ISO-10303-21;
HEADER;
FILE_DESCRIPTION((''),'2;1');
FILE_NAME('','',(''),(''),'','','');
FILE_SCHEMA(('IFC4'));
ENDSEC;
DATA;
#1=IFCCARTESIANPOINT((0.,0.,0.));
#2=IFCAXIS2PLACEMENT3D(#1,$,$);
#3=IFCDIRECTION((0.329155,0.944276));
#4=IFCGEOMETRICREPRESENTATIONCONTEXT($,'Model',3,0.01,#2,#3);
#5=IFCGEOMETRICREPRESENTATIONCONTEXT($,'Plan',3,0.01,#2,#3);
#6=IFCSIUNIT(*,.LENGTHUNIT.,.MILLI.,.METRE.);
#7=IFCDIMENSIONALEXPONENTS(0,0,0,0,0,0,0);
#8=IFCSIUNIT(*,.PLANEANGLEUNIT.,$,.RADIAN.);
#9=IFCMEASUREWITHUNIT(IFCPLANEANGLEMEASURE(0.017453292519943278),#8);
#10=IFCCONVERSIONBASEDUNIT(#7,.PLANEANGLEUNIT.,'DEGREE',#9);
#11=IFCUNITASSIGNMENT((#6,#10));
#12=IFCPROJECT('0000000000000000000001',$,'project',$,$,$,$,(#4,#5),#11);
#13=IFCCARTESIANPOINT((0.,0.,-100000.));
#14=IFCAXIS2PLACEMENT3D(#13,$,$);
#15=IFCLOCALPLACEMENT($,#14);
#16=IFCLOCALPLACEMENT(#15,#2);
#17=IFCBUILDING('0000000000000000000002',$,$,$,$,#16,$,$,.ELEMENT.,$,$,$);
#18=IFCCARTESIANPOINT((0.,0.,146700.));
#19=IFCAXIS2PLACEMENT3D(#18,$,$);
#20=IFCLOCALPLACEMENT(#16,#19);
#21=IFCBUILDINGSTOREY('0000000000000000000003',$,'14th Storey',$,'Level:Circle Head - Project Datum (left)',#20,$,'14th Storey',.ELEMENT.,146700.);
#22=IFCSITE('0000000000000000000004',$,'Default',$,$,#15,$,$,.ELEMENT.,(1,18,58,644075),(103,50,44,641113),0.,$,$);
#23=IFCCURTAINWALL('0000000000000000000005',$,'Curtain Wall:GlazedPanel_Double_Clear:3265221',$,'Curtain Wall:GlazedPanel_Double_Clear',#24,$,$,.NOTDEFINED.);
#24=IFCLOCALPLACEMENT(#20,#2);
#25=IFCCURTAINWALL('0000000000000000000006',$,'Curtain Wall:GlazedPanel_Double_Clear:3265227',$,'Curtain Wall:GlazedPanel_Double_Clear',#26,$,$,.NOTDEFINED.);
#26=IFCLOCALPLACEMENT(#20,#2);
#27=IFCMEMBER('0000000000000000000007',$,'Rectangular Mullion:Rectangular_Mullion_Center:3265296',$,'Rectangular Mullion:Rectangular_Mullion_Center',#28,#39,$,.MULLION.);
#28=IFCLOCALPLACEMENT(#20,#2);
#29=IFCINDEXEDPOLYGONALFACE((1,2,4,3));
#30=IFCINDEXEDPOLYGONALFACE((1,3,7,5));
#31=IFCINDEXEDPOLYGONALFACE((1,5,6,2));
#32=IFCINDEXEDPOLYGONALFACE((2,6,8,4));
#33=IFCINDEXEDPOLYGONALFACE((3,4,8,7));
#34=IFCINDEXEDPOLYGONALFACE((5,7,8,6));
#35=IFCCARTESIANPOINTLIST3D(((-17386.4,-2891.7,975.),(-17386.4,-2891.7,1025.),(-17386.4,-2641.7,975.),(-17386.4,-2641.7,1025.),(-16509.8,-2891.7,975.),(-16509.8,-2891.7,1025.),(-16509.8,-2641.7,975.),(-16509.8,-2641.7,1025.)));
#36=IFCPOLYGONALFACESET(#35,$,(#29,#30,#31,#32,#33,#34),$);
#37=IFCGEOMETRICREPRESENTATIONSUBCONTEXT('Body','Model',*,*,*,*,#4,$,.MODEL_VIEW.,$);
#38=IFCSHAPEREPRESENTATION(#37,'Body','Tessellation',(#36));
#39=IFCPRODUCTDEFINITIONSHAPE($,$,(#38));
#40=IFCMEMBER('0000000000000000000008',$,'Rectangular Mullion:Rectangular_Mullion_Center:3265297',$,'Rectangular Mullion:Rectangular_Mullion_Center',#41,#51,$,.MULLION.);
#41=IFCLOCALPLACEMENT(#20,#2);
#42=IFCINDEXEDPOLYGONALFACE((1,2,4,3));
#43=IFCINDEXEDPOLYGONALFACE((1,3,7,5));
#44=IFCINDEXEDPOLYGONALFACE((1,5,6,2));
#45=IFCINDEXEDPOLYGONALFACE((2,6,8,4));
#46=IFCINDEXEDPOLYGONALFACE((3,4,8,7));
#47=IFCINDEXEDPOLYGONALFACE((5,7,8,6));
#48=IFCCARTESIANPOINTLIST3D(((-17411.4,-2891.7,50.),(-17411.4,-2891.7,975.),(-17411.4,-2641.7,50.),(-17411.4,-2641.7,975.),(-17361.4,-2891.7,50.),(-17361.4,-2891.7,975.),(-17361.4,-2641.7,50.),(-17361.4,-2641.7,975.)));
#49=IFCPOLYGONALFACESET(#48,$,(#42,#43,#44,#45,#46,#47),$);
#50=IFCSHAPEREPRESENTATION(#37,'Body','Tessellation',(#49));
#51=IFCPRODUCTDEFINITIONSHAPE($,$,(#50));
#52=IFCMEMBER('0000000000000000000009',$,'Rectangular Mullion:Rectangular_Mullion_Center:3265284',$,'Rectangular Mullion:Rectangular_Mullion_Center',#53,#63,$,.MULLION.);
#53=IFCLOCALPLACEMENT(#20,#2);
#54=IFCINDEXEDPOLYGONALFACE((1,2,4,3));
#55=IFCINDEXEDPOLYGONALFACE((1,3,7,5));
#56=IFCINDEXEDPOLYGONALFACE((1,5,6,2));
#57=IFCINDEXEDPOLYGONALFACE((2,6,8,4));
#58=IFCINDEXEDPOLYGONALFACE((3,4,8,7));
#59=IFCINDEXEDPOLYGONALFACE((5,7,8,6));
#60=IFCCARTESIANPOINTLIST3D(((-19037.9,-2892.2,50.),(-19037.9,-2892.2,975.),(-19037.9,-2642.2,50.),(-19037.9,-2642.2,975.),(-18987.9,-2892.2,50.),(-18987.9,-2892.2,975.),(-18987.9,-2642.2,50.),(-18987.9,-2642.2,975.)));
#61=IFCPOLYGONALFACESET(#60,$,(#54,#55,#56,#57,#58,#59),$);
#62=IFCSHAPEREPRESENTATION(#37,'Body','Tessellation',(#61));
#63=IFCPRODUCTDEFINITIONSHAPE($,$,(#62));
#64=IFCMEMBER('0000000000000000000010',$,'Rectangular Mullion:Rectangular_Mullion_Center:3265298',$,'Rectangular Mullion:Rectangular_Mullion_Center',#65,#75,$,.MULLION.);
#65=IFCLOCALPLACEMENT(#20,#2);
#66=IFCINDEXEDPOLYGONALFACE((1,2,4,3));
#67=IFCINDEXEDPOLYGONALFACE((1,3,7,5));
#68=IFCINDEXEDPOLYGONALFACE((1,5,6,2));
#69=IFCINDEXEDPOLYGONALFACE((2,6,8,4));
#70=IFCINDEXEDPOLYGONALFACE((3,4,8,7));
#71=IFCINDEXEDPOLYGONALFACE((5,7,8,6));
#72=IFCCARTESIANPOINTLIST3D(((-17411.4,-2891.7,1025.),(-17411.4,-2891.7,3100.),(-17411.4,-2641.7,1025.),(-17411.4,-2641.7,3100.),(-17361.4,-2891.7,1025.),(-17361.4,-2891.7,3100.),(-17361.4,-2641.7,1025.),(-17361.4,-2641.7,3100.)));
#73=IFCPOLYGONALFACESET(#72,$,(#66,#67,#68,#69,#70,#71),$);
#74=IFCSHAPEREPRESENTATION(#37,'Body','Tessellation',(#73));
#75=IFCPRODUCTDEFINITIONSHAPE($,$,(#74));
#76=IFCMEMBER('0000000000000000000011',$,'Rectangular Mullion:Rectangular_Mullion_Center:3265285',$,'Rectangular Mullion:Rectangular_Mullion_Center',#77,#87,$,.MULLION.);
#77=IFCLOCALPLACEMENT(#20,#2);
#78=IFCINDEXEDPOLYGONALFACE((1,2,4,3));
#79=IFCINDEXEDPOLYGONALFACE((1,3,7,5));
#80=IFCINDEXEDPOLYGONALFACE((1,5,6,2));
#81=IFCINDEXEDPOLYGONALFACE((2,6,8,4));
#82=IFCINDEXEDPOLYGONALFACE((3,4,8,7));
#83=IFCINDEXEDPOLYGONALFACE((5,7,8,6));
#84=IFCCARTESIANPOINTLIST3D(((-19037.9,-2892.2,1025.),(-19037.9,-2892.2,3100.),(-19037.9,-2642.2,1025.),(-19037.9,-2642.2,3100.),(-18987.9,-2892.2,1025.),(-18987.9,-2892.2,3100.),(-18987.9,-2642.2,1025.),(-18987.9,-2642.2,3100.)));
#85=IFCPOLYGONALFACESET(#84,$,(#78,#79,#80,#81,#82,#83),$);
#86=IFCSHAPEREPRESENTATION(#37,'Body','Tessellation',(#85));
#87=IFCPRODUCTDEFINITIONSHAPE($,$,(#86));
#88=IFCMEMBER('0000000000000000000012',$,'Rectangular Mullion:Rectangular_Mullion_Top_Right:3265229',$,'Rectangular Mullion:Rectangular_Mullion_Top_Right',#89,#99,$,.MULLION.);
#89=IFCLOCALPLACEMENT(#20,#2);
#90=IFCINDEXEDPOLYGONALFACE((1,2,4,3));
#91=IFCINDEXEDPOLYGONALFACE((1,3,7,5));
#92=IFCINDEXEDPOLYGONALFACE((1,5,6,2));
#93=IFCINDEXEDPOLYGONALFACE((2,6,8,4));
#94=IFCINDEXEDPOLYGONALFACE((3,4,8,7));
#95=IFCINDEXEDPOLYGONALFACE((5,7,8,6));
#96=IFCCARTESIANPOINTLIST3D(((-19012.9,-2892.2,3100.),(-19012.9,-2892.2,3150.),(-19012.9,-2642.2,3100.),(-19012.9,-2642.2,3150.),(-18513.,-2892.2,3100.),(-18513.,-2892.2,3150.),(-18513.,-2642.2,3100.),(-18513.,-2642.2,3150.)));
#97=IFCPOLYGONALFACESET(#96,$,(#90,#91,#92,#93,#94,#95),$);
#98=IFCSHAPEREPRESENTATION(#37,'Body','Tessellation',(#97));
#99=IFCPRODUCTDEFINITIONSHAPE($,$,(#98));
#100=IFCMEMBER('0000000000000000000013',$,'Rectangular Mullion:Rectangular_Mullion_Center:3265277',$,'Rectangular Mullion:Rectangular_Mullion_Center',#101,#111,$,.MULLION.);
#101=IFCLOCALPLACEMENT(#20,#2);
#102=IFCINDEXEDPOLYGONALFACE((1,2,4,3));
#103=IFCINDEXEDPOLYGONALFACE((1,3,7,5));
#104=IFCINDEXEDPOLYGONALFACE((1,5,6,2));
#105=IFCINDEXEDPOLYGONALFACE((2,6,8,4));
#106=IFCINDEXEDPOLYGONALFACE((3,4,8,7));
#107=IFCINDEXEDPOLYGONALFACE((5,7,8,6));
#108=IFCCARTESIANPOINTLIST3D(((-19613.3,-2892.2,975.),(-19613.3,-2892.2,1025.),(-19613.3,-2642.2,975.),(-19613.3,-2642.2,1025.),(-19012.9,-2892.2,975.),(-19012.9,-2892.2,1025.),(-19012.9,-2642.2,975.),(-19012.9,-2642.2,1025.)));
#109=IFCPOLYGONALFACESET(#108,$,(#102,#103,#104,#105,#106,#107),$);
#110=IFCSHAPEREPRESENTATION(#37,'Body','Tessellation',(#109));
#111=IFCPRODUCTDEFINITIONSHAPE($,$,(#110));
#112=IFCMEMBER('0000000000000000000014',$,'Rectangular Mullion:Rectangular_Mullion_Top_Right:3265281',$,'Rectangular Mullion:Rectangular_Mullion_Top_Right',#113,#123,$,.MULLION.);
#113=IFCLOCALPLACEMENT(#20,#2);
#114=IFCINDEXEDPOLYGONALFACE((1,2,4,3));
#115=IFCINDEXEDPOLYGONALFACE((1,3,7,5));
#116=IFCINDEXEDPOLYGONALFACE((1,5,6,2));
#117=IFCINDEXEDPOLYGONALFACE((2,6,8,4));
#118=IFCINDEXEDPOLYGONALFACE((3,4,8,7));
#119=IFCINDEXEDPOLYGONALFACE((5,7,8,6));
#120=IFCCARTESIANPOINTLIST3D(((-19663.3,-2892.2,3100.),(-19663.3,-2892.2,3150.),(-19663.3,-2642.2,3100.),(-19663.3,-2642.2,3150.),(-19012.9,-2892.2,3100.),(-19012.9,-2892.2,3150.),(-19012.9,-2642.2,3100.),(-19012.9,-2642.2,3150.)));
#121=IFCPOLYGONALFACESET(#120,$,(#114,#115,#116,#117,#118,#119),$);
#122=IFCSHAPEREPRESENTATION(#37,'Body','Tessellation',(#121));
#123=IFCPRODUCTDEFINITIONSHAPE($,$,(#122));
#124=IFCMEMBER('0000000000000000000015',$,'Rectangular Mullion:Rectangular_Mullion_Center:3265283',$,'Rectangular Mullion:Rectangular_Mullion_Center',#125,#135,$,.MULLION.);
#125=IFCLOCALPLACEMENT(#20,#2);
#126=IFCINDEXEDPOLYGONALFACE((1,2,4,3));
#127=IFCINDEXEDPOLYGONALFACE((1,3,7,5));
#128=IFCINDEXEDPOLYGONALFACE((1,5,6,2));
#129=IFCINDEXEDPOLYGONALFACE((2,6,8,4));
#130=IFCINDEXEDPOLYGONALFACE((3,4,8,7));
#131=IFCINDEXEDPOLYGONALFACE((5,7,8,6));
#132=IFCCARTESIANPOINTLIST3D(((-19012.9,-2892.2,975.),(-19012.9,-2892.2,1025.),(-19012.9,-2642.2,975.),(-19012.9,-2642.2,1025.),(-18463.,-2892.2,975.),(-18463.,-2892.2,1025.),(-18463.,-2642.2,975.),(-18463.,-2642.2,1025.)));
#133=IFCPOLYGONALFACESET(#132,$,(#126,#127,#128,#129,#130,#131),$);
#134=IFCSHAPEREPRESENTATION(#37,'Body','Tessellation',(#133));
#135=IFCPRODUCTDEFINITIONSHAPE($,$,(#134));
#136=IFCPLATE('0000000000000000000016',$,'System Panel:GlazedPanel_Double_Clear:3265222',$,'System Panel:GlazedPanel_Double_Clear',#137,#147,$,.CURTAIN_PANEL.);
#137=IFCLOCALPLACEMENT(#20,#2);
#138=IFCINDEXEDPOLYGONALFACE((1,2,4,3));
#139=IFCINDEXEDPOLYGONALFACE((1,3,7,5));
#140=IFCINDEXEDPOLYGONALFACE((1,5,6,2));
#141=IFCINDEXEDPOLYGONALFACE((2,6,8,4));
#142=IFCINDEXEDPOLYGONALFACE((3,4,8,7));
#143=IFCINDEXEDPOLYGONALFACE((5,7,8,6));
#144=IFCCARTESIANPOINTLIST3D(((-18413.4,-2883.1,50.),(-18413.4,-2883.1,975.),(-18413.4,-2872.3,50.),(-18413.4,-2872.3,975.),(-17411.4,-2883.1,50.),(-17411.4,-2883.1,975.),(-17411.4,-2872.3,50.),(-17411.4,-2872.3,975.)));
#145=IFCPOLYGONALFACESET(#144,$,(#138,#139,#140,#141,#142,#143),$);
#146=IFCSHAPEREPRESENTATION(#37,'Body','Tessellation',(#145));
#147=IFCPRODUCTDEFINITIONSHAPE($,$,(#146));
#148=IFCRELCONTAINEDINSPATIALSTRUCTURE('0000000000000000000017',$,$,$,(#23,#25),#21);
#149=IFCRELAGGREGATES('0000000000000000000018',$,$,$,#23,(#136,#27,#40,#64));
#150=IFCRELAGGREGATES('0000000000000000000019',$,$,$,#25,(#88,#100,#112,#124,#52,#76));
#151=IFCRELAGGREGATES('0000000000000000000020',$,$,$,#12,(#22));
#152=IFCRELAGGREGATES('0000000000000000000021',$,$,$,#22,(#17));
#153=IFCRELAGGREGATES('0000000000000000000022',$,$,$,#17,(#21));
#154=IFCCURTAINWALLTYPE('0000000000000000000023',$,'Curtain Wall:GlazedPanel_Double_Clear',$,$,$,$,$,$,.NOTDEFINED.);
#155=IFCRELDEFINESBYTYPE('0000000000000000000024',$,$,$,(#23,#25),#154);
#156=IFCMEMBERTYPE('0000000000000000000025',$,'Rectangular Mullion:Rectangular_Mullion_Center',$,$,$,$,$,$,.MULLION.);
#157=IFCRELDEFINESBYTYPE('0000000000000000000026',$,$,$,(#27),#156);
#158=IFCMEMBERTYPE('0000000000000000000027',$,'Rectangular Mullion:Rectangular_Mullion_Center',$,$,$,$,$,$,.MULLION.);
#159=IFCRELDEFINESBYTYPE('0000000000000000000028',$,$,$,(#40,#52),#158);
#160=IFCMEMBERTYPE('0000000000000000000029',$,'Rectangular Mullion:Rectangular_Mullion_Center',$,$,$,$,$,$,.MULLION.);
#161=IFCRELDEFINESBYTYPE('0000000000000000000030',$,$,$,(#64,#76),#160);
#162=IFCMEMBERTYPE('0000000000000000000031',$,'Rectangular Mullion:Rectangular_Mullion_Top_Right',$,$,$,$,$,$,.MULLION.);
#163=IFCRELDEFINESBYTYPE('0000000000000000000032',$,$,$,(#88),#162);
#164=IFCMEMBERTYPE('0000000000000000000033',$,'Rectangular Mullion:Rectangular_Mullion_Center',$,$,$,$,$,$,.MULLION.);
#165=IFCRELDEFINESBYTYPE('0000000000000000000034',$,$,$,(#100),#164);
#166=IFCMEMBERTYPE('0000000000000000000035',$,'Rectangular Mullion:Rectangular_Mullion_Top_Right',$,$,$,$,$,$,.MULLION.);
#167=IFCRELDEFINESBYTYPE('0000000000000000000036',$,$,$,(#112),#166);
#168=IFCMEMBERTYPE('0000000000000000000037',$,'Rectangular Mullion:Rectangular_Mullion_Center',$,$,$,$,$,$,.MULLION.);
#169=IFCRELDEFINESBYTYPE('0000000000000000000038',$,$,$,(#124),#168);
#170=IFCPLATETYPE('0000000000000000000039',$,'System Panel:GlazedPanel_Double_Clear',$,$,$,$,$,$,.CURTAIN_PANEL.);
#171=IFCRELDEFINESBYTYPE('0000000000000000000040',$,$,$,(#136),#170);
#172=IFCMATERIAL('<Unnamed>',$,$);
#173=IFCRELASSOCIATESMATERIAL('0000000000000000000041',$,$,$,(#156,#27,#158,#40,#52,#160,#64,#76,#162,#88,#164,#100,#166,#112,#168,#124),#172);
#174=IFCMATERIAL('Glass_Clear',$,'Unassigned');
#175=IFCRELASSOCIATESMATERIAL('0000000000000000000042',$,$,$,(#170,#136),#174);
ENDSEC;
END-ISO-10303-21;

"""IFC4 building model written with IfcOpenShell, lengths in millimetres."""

from ifc_helpers import new_model, entity, si_unit, converted_unit, direction, frame, origin, place, context, subcontext, project, spatial, indexed_curve, outline, extrude, source, transform, mapped, material, type_object, type_shapes, element, aggregate, save


model = new_model("IFC4")

# Units and contexts
model_context = context("Model", 3, precision=0.01, world=origin(), true_north=direction((0.329155, 0.944276)))
plan_context = context("Plan", 3, precision=0.01, world=origin(), true_north=direction((0.329155, 0.944276)))
body_context = subcontext(model_context, "Body", "Model", "MODEL_VIEW")
ifc_project = project(units=[si_unit("LENGTHUNIT", "METRE", prefix="MILLI"), converted_unit("PLANEANGLEUNIT", "DEGREE", entity("IfcPlaneAngleMeasure", 0.017453292519943278), si_unit("PLANEANGLEUNIT", "RADIAN"), dimensions=[0, 0, 0, 0, 0, 0, 0])], contexts=[model_context, plan_context])

# Site, building, storey
site_placement = place(None, frame((0.0, 0.0, -100000.0)))
site = spatial("IfcSite", under=ifc_project, at=site_placement, Name="Default", CompositionType="ELEMENT", RefLatitude=(1, 18, 58, 644075), RefLongitude=(103, 50, 44, 641113), RefElevation=0.0)
building_placement = place(site_placement, origin())
building = spatial("IfcBuilding", under=site, at=building_placement, CompositionType="ELEMENT")
storey_placement = place(building_placement, frame((0.0, 0.0, 146700.0)))
storey = spatial("IfcBuildingStorey", under=building, at=storey_placement, Name="14th Storey", ObjectType="Level:Circle Head - Project Datum (left)", LongName="14th Storey", CompositionType="ELEMENT", Elevation=146700.0)

# Curtain wall
curtain_wall_type = type_object("IfcCurtainWallType", Name="Curtain Wall:GlazedPanel_Double_Clear", PredefinedType="NOTDEFINED")
curtain_wall_1_placement = place(storey_placement, frame((0.0, 0.0, -146700.0)))
curtain_wall_1 = element("IfcCurtainWall", 1, at=curtain_wall_1_placement, inside=storey, type_object=curtain_wall_type, Name="Curtain Wall:GlazedPanel_Double_Clear:3265221", ObjectType="Curtain Wall:GlazedPanel_Double_Clear", PredefinedType="NOTDEFINED")
ifc_material_1 = material(Name="<Unnamed>")

# Curtain wall
curtain_wall_2_placement = place(storey_placement, frame((0.0, 0.0, -146700.0)))
curtain_wall_2 = element("IfcCurtainWall", 2, at=curtain_wall_2_placement, inside=storey, type_object=curtain_wall_type, Name="Curtain Wall:GlazedPanel_Double_Clear:3265227", ObjectType="Curtain Wall:GlazedPanel_Double_Clear", PredefinedType="NOTDEFINED")

# Members
member_type_1 = type_object("IfcMemberType", Name="Rectangular Mullion:Rectangular_Mullion_Center", PredefinedType="MULLION", material=ifc_material_1)
shared_shape_1 = source(origin(), body_context, "Body", "SweptSolid", [
    extrude(outline(indexed_curve([(-25.0, -125.0), (25.0, -125.0), (25.0, 125.0), (-25.0, 125.0), (-25.0, -125.0)], self_intersect=False)), frame((0.0, 0.0, -876.6), z_axis=(0.0, 0.0, 1.0), x_axis=(-1.0, 0.0, 0.0)), (0.0, 0.0, 1.0), 876.6),
])
type_shapes(member_type_1, [shared_shape_1])
member_1_placement = place(curtain_wall_1_placement, frame((-16509.8, -2766.7, 147700.0), z_axis=(1.0, 0.0, 0.0), x_axis=(0.0, 0.0, 1.0)))
member_1 = element("IfcMember", 3, at=member_1_placement, type_object=member_type_1, material=ifc_material_1, Name="Rectangular Mullion:Rectangular_Mullion_Center:3265296", ObjectType="Rectangular Mullion:Rectangular_Mullion_Center", PredefinedType="MULLION", context=body_context, shape_type="MappedRepresentation", body=[
    mapped(shared_shape_1, transform((0.0, 0.0, 0.0), scale=1.0)),
])
member_type_2 = type_object("IfcMemberType", Name="Rectangular Mullion:Rectangular_Mullion_Center", PredefinedType="MULLION", material=ifc_material_1)
shared_shape_2 = source(origin(), body_context, "Body", "SweptSolid", [
    extrude(outline(indexed_curve([(-25.0, -125.0), (25.0, -125.0), (25.0, 125.0), (-25.0, 125.0), (-25.0, -125.0)], self_intersect=False)), frame((0.0, 0.0, -925.0), z_axis=(0.0, 0.0, 1.0), x_axis=(-1.0, 0.0, 0.0)), (0.0, 0.0, 1.0), 925.0),
])
type_shapes(member_type_2, [shared_shape_2])
member_2_placement = place(curtain_wall_1_placement, frame((-17386.4, -2766.7, 146750.0), z_axis=(0.0, 0.0, -1.0), x_axis=(1.0, 0.0, 0.0)))
member_2 = element("IfcMember", 4, at=member_2_placement, type_object=member_type_2, material=ifc_material_1, Name="Rectangular Mullion:Rectangular_Mullion_Center:3265297", ObjectType="Rectangular Mullion:Rectangular_Mullion_Center", PredefinedType="MULLION", context=body_context, shape_type="MappedRepresentation", body=[
    mapped(shared_shape_2, transform((0.0, 0.0, 0.0), scale=1.0)),
])
member_3_placement = place(curtain_wall_2_placement, frame((-19012.9, -2767.2, 146750.0), z_axis=(0.0, 0.0, -1.0), x_axis=(1.0, 0.0, 0.0)))
member_3 = element("IfcMember", 5, at=member_3_placement, type_object=member_type_2, material=ifc_material_1, Name="Rectangular Mullion:Rectangular_Mullion_Center:3265284", ObjectType="Rectangular Mullion:Rectangular_Mullion_Center", PredefinedType="MULLION", context=body_context, shape_type="MappedRepresentation", body=[
    mapped(shared_shape_2, transform((0.0, 0.0, 0.0), scale=1.0)),
])
member_type_3 = type_object("IfcMemberType", Name="Rectangular Mullion:Rectangular_Mullion_Center", PredefinedType="MULLION", material=ifc_material_1)
shared_shape_3 = source(origin(), body_context, "Body", "SweptSolid", [
    extrude(outline(indexed_curve([(-25.0, -125.0), (25.0, -125.0), (25.0, 125.0), (-25.0, 125.0), (-25.0, -125.0)], self_intersect=False)), frame((0.0, 0.0, -2075.0), z_axis=(0.0, 0.0, 1.0), x_axis=(-1.0, 0.0, 0.0)), (0.0, 0.0, 1.0), 2075.0),
])
type_shapes(member_type_3, [shared_shape_3])
member_4_placement = place(curtain_wall_1_placement, frame((-17386.4, -2766.7, 147725.0), z_axis=(0.0, 0.0, -1.0), x_axis=(1.0, 0.0, 0.0)))
member_4 = element("IfcMember", 6, at=member_4_placement, type_object=member_type_3, material=ifc_material_1, Name="Rectangular Mullion:Rectangular_Mullion_Center:3265298", ObjectType="Rectangular Mullion:Rectangular_Mullion_Center", PredefinedType="MULLION", context=body_context, shape_type="MappedRepresentation", body=[
    mapped(shared_shape_3, transform((0.0, 0.0, 0.0), scale=1.0)),
])
member_5_placement = place(curtain_wall_2_placement, frame((-19012.9, -2767.2, 147725.0), z_axis=(0.0, 0.0, -1.0), x_axis=(1.0, 0.0, 0.0)))
member_5 = element("IfcMember", 7, at=member_5_placement, type_object=member_type_3, material=ifc_material_1, Name="Rectangular Mullion:Rectangular_Mullion_Center:3265285", ObjectType="Rectangular Mullion:Rectangular_Mullion_Center", PredefinedType="MULLION", context=body_context, shape_type="MappedRepresentation", body=[
    mapped(shared_shape_3, transform((0.0, 0.0, 0.0), scale=1.0)),
])
member_type_4 = type_object("IfcMemberType", Name="Rectangular Mullion:Rectangular_Mullion_Top_Right", PredefinedType="MULLION", material=ifc_material_1)
shared_shape_4 = source(origin(), body_context, "Body", "SweptSolid", [
    extrude(outline(indexed_curve([(-25.0, -125.0), (25.0, -125.0), (25.0, 125.0), (-25.0, 125.0), (-25.0, -125.0)], self_intersect=False)), frame((-25.0, 0.0, -499.9), z_axis=(0.0, 0.0, 1.0), x_axis=(-1.0, 0.0, 0.0)), (0.0, 0.0, 1.0), 499.9),
])
type_shapes(member_type_4, [shared_shape_4])
member_6_placement = place(curtain_wall_2_placement, frame((-18513.0, -2767.2, 149850.0), z_axis=(1.0, 0.0, 0.0), x_axis=(0.0, 0.0, 1.0)))
member_6 = element("IfcMember", 8, at=member_6_placement, type_object=member_type_4, material=ifc_material_1, Name="Rectangular Mullion:Rectangular_Mullion_Top_Right:3265229", ObjectType="Rectangular Mullion:Rectangular_Mullion_Top_Right", PredefinedType="MULLION", context=body_context, shape_type="MappedRepresentation", body=[
    mapped(shared_shape_4, transform((0.0, 0.0, 0.0), scale=1.0)),
])
member_type_5 = type_object("IfcMemberType", Name="Rectangular Mullion:Rectangular_Mullion_Center", PredefinedType="MULLION", material=ifc_material_1)
shared_shape_5 = source(origin(), body_context, "Body", "SweptSolid", [
    extrude(outline(indexed_curve([(-25.0, -125.0), (25.0, -125.0), (25.0, 125.0), (-25.0, 125.0), (-25.0, -125.0)], self_intersect=False)), frame((0.0, 0.0, -600.4), z_axis=(0.0, 0.0, 1.0), x_axis=(-1.0, 0.0, 0.0)), (0.0, 0.0, 1.0), 600.4),
])
type_shapes(member_type_5, [shared_shape_5])
member_7_placement = place(curtain_wall_2_placement, frame((-19012.9, -2767.2, 147700.0), z_axis=(1.0, 0.0, 0.0), x_axis=(0.0, 0.0, 1.0)))
member_7 = element("IfcMember", 9, at=member_7_placement, type_object=member_type_5, material=ifc_material_1, Name="Rectangular Mullion:Rectangular_Mullion_Center:3265277", ObjectType="Rectangular Mullion:Rectangular_Mullion_Center", PredefinedType="MULLION", context=body_context, shape_type="MappedRepresentation", body=[
    mapped(shared_shape_5, transform((0.0, 0.0, 0.0), scale=1.0)),
])
member_type_6 = type_object("IfcMemberType", Name="Rectangular Mullion:Rectangular_Mullion_Top_Right", PredefinedType="MULLION", material=ifc_material_1)
shared_shape_6 = source(origin(), body_context, "Body", "SweptSolid", [
    extrude(outline(indexed_curve([(-25.0, -125.0), (25.0, -125.0), (25.0, 125.0), (-25.0, 125.0), (-25.0, -125.0)], self_intersect=False)), frame((-25.0, 0.0, -650.4), z_axis=(0.0, 0.0, 1.0), x_axis=(-1.0, 0.0, 0.0)), (0.0, 0.0, 1.0), 650.4),
])
type_shapes(member_type_6, [shared_shape_6])
member_8_placement = place(curtain_wall_2_placement, frame((-19012.9, -2767.2, 149850.0), z_axis=(1.0, 0.0, 0.0), x_axis=(0.0, 0.0, 1.0)))
member_8 = element("IfcMember", 10, at=member_8_placement, type_object=member_type_6, material=ifc_material_1, Name="Rectangular Mullion:Rectangular_Mullion_Top_Right:3265281", ObjectType="Rectangular Mullion:Rectangular_Mullion_Top_Right", PredefinedType="MULLION", context=body_context, shape_type="MappedRepresentation", body=[
    mapped(shared_shape_6, transform((0.0, 0.0, 0.0), scale=1.0)),
])
member_type_7 = type_object("IfcMemberType", Name="Rectangular Mullion:Rectangular_Mullion_Center", PredefinedType="MULLION", material=ifc_material_1)
shared_shape_7 = source(origin(), body_context, "Body", "SweptSolid", [
    extrude(outline(indexed_curve([(-25.0, -125.0), (25.0, -125.0), (25.0, 125.0), (-25.0, 125.0), (-25.0, -125.0)], self_intersect=False)), frame((0.0, 0.0, -549.9), z_axis=(0.0, 0.0, 1.0), x_axis=(-1.0, 0.0, 0.0)), (0.0, 0.0, 1.0), 549.9),
])
type_shapes(member_type_7, [shared_shape_7])
member_9_placement = place(curtain_wall_2_placement, frame((-18463.0, -2767.2, 147700.0), z_axis=(1.0, 0.0, 0.0), x_axis=(0.0, 0.0, 1.0)))
member_9 = element("IfcMember", 11, at=member_9_placement, type_object=member_type_7, material=ifc_material_1, Name="Rectangular Mullion:Rectangular_Mullion_Center:3265283", ObjectType="Rectangular Mullion:Rectangular_Mullion_Center", PredefinedType="MULLION", context=body_context, shape_type="MappedRepresentation", body=[
    mapped(shared_shape_7, transform((0.0, 0.0, 0.0), scale=1.0)),
])

# Plate
ifc_material_2 = material(Name="Glass_Clear", Category="Unassigned")
plate_type_1 = type_object("IfcPlateType", Name="System Panel:GlazedPanel_Double_Clear", PredefinedType="CURTAIN_PANEL", material=ifc_material_2)
shared_shape_8 = source(origin(), body_context, "Body", "SweptSolid", [
    extrude(outline(indexed_curve([(-5.4, -501.0), (5.4, -501.0), (5.4, 501.0), (-5.4, 501.0), (-5.4, -501.0)], self_intersect=False)), frame((501.0, 5.4, 0.0), z_axis=(0.0, 0.0, 1.0), x_axis=(0.0, 1.0, 0.0)), (0.0, 0.0, 1.0), 925.0),
])
type_shapes(plate_type_1, [shared_shape_8])
plate_1_placement = place(curtain_wall_1_placement, frame((-18413.4, -2883.1, 146750.0)))
plate_1 = element("IfcPlate", 12, at=plate_1_placement, type_object=plate_type_1, material=ifc_material_2, Name="System Panel:GlazedPanel_Double_Clear:3265222", ObjectType="System Panel:GlazedPanel_Double_Clear", PredefinedType="CURTAIN_PANEL", context=body_context, shape_type="MappedRepresentation", body=[
    mapped(shared_shape_8, transform((0.0, 0.0, 0.0), scale=1.0)),
])
aggregate(curtain_wall_1, [plate_1, member_1, member_2, member_4])
aggregate(curtain_wall_2, [member_6, member_7, member_8, member_9, member_3, member_5])

save(model, "model.ifc")
